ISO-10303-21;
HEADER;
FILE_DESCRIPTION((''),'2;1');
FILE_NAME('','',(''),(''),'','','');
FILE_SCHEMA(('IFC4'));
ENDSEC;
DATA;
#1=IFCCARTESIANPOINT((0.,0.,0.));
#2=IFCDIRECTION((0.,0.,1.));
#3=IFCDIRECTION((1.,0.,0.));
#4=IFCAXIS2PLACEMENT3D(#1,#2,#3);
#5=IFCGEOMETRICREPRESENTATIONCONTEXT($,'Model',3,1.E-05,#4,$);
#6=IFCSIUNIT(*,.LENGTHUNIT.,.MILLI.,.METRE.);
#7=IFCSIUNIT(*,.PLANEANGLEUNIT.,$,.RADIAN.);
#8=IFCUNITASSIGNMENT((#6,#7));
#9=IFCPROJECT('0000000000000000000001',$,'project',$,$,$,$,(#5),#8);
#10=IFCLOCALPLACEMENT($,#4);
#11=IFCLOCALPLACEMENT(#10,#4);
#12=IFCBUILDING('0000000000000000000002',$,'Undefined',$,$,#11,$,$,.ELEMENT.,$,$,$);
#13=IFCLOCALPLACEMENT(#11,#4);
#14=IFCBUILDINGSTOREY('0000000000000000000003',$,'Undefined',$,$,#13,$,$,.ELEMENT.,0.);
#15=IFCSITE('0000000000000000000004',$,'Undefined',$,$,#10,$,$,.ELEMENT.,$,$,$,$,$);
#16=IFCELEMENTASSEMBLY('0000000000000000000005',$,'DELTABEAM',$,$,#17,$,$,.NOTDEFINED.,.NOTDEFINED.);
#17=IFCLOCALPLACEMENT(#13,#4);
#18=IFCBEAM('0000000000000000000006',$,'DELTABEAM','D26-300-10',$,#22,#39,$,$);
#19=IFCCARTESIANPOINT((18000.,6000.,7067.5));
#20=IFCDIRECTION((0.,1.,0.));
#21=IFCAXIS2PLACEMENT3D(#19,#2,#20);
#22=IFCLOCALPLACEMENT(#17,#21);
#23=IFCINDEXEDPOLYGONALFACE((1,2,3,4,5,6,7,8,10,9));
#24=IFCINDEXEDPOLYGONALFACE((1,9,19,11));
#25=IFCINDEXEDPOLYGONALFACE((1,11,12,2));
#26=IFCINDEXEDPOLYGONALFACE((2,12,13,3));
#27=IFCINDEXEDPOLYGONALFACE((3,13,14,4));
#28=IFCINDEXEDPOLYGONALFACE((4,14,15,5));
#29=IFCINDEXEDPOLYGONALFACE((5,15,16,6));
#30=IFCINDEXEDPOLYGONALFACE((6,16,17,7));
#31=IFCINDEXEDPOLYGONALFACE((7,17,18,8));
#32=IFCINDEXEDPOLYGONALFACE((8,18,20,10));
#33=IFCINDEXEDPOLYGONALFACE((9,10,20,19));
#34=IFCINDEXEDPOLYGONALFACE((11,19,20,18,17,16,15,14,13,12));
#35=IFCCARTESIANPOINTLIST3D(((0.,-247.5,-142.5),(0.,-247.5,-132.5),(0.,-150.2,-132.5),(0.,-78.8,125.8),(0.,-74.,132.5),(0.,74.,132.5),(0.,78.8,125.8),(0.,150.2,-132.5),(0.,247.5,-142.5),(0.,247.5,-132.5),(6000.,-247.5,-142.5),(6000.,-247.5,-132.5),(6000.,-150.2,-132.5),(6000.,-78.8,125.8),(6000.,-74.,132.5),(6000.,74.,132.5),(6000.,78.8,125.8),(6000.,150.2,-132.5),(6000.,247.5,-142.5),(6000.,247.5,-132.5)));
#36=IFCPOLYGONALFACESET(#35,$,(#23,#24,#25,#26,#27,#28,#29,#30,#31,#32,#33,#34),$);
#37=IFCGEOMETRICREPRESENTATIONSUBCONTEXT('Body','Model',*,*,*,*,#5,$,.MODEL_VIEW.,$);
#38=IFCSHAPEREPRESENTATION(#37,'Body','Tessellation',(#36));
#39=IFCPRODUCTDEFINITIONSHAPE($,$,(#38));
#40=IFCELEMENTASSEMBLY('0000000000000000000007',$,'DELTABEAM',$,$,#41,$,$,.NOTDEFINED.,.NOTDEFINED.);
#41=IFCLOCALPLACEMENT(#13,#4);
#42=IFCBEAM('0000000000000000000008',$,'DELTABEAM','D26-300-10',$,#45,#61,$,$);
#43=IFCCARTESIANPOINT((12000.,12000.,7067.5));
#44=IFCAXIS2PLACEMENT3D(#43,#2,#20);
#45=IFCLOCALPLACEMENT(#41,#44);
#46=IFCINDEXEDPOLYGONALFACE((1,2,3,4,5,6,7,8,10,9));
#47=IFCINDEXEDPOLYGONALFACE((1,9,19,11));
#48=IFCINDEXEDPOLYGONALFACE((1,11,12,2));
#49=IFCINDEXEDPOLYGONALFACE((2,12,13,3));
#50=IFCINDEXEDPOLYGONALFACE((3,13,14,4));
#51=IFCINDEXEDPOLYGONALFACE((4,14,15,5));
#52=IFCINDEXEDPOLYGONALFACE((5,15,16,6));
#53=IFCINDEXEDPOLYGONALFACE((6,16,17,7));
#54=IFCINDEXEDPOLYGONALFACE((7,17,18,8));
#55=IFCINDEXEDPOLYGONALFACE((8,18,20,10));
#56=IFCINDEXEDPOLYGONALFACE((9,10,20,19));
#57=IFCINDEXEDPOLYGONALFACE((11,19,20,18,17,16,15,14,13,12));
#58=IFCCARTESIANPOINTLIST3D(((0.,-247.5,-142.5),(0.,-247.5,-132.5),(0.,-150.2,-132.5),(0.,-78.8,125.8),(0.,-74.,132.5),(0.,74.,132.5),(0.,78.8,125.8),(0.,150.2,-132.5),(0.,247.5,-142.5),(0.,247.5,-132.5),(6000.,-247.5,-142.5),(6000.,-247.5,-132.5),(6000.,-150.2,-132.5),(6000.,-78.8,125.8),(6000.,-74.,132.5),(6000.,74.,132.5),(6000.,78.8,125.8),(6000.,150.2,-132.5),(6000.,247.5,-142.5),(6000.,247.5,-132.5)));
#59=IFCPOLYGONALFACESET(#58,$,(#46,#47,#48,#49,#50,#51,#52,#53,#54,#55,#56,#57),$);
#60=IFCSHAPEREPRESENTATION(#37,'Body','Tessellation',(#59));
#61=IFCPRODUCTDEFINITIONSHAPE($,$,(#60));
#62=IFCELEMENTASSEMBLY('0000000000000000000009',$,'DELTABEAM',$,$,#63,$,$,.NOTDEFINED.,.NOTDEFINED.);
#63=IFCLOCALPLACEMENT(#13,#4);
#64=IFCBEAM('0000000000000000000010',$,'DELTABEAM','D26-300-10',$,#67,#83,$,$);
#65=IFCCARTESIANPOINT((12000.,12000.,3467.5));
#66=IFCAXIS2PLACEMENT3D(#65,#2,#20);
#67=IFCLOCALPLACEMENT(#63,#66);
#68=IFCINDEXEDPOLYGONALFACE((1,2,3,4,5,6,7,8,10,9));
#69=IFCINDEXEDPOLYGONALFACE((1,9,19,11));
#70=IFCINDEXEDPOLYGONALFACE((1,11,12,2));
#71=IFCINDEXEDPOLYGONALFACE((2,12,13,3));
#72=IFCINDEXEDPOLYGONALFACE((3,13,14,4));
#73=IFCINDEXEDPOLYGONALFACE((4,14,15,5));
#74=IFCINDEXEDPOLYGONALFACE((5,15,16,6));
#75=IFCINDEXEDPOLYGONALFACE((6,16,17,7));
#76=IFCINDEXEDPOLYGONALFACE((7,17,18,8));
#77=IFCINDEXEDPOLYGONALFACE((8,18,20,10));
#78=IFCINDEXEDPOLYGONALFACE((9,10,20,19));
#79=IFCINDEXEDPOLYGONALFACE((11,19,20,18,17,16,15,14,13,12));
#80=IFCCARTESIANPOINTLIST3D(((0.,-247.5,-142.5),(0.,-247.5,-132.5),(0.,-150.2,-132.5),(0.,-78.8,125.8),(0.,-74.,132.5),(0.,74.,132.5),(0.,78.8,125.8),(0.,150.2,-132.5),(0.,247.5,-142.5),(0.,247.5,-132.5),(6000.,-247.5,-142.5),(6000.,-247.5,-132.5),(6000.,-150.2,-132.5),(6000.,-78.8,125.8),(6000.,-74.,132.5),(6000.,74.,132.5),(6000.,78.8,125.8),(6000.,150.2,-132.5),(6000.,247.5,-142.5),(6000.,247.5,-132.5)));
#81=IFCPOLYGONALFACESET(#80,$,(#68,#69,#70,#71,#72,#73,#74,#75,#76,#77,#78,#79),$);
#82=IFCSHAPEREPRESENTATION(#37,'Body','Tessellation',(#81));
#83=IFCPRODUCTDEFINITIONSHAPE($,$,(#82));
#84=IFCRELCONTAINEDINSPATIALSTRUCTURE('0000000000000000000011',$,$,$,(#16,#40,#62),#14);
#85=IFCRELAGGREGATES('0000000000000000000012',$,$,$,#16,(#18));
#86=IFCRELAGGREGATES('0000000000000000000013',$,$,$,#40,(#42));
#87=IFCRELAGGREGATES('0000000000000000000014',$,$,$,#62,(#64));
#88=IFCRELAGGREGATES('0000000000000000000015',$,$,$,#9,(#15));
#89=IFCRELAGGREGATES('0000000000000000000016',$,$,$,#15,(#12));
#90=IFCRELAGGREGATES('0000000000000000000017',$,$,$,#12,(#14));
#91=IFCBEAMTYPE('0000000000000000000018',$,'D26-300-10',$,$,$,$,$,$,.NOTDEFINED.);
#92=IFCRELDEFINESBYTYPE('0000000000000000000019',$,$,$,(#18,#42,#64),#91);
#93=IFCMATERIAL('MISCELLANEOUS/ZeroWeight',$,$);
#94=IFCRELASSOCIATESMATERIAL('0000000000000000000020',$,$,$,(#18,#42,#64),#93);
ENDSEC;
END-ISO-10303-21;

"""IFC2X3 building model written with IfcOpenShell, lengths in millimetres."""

from ifc_helpers import new_model, si_unit, frame, origin_with_axes, place, context, subcontext, project, spatial, polyline, outline, extrude, material, type_object, element, aggregate, save


model = new_model("IFC2X3")

# Units and contexts
model_context = context("Model", 3, precision=1e-05, world=origin_with_axes())
body_context = subcontext(model_context, "Body", "Model", "MODEL_VIEW")
ifc_project = project(units=[si_unit("LENGTHUNIT", "METRE", prefix="MILLI"), si_unit("PLANEANGLEUNIT", "RADIAN")], contexts=[model_context])

# Site, building, storey
site_placement = place(None, origin_with_axes())
site = spatial("IfcSite", under=ifc_project, at=site_placement, Name="Undefined", CompositionType="ELEMENT")
building_placement = place(site_placement, origin_with_axes())
building = spatial("IfcBuilding", under=site, at=building_placement, Name="Undefined", CompositionType="ELEMENT")
storey_placement = place(building_placement, origin_with_axes())
storey = spatial("IfcBuildingStorey", under=building, at=storey_placement, Name="Undefined", CompositionType="ELEMENT", Elevation=0.0)

# Element assemblies, beams
assembly_1_placement = place(storey_placement, origin_with_axes())
assembly_1 = element("IfcElementAssembly", 1, at=assembly_1_placement, inside=storey, Name="DELTABEAM", AssemblyPlace="NOTDEFINED", PredefinedType="NOTDEFINED")
ifc_material_1 = material(Name="MISCELLANEOUS/ZeroWeight")
beam_type = type_object("IfcBeamType", Name="D26-300-10", PredefinedType="NOTDEFINED")
beam_1_placement = place(assembly_1_placement, frame((18000.0, 6000.0, 7067.5), z_axis=(0.0, 0.0, 1.0), x_axis=(0.0, 1.0, 0.0)))
beam_1 = element("IfcBeam", 2, at=beam_1_placement, type_object=beam_type, material=ifc_material_1, Name="DELTABEAM", Description="D26-300-10", context=body_context, shape_type="SweptSolid", body=[
    extrude(outline(polyline([(-75.1, 120.5), (-145.0, -132.5), (247.5, -132.5), (247.5, -142.5), (-247.5, -142.5), (-247.5, -132.5), (-150.2, -132.5), (-78.8, 125.8), (-74.0, 132.5), (74.0, 132.5), (78.8, 125.8), (150.2, -132.5), (145.0, -132.5), (75.1, 120.5), (-75.1, 120.5)])), frame((6000.0, 0.0, 0.0), z_axis=(-1.0, 0.0, 0.0), x_axis=(0.0, -1.0, 0.0)), (0.0, 0.0, 1.0), 6000.0),
])
aggregate(assembly_1, [beam_1])
assembly_2_placement = place(storey_placement, origin_with_axes())
assembly_2 = element("IfcElementAssembly", 3, at=assembly_2_placement, inside=storey, Name="DELTABEAM", AssemblyPlace="NOTDEFINED", PredefinedType="NOTDEFINED")
beam_2_placement = place(assembly_2_placement, frame((12000.0, 12000.0, 7067.5), z_axis=(0.0, 0.0, 1.0), x_axis=(0.0, 1.0, 0.0)))
beam_2 = element("IfcBeam", 4, at=beam_2_placement, type_object=beam_type, material=ifc_material_1, Name="DELTABEAM", Description="D26-300-10", context=body_context, shape_type="SweptSolid", body=[
    extrude(outline(polyline([(-75.1, 120.5), (-145.0, -132.5), (247.5, -132.5), (247.5, -142.5), (-247.5, -142.5), (-247.5, -132.5), (-150.2, -132.5), (-78.8, 125.8), (-74.0, 132.5), (74.0, 132.5), (78.8, 125.8), (150.2, -132.5), (145.0, -132.5), (75.1, 120.5), (-75.1, 120.5)])), frame((6000.0, 0.0, 0.0), z_axis=(-1.0, 0.0, 0.0), x_axis=(0.0, -1.0, 0.0)), (0.0, 0.0, 1.0), 6000.0),
])
aggregate(assembly_2, [beam_2])
assembly_3_placement = place(storey_placement, origin_with_axes())
assembly_3 = element("IfcElementAssembly", 5, at=assembly_3_placement, inside=storey, Name="DELTABEAM", AssemblyPlace="NOTDEFINED", PredefinedType="NOTDEFINED")
beam_3_placement = place(assembly_3_placement, frame((12000.0, 12000.0, 3467.5), z_axis=(0.0, 0.0, 1.0), x_axis=(0.0, 1.0, 0.0)))
beam_3 = element("IfcBeam", 6, at=beam_3_placement, type_object=beam_type, material=ifc_material_1, Name="DELTABEAM", Description="D26-300-10", context=body_context, shape_type="SweptSolid", body=[
    extrude(outline(polyline([(-75.1, 120.5), (-145.0, -132.5), (247.5, -132.5), (247.5, -142.5), (-247.5, -142.5), (-247.5, -132.5), (-150.2, -132.5), (-78.8, 125.8), (-74.0, 132.5), (74.0, 132.5), (78.8, 125.8), (150.2, -132.5), (145.0, -132.5), (75.1, 120.5), (-75.1, 120.5)])), frame((6000.0, 0.0, 0.0), z_axis=(-1.0, 0.0, 0.0), x_axis=(0.0, -1.0, 0.0)), (0.0, 0.0, 1.0), 6000.0),
])
aggregate(assembly_3, [beam_3])

save(model, "model.ifc")
